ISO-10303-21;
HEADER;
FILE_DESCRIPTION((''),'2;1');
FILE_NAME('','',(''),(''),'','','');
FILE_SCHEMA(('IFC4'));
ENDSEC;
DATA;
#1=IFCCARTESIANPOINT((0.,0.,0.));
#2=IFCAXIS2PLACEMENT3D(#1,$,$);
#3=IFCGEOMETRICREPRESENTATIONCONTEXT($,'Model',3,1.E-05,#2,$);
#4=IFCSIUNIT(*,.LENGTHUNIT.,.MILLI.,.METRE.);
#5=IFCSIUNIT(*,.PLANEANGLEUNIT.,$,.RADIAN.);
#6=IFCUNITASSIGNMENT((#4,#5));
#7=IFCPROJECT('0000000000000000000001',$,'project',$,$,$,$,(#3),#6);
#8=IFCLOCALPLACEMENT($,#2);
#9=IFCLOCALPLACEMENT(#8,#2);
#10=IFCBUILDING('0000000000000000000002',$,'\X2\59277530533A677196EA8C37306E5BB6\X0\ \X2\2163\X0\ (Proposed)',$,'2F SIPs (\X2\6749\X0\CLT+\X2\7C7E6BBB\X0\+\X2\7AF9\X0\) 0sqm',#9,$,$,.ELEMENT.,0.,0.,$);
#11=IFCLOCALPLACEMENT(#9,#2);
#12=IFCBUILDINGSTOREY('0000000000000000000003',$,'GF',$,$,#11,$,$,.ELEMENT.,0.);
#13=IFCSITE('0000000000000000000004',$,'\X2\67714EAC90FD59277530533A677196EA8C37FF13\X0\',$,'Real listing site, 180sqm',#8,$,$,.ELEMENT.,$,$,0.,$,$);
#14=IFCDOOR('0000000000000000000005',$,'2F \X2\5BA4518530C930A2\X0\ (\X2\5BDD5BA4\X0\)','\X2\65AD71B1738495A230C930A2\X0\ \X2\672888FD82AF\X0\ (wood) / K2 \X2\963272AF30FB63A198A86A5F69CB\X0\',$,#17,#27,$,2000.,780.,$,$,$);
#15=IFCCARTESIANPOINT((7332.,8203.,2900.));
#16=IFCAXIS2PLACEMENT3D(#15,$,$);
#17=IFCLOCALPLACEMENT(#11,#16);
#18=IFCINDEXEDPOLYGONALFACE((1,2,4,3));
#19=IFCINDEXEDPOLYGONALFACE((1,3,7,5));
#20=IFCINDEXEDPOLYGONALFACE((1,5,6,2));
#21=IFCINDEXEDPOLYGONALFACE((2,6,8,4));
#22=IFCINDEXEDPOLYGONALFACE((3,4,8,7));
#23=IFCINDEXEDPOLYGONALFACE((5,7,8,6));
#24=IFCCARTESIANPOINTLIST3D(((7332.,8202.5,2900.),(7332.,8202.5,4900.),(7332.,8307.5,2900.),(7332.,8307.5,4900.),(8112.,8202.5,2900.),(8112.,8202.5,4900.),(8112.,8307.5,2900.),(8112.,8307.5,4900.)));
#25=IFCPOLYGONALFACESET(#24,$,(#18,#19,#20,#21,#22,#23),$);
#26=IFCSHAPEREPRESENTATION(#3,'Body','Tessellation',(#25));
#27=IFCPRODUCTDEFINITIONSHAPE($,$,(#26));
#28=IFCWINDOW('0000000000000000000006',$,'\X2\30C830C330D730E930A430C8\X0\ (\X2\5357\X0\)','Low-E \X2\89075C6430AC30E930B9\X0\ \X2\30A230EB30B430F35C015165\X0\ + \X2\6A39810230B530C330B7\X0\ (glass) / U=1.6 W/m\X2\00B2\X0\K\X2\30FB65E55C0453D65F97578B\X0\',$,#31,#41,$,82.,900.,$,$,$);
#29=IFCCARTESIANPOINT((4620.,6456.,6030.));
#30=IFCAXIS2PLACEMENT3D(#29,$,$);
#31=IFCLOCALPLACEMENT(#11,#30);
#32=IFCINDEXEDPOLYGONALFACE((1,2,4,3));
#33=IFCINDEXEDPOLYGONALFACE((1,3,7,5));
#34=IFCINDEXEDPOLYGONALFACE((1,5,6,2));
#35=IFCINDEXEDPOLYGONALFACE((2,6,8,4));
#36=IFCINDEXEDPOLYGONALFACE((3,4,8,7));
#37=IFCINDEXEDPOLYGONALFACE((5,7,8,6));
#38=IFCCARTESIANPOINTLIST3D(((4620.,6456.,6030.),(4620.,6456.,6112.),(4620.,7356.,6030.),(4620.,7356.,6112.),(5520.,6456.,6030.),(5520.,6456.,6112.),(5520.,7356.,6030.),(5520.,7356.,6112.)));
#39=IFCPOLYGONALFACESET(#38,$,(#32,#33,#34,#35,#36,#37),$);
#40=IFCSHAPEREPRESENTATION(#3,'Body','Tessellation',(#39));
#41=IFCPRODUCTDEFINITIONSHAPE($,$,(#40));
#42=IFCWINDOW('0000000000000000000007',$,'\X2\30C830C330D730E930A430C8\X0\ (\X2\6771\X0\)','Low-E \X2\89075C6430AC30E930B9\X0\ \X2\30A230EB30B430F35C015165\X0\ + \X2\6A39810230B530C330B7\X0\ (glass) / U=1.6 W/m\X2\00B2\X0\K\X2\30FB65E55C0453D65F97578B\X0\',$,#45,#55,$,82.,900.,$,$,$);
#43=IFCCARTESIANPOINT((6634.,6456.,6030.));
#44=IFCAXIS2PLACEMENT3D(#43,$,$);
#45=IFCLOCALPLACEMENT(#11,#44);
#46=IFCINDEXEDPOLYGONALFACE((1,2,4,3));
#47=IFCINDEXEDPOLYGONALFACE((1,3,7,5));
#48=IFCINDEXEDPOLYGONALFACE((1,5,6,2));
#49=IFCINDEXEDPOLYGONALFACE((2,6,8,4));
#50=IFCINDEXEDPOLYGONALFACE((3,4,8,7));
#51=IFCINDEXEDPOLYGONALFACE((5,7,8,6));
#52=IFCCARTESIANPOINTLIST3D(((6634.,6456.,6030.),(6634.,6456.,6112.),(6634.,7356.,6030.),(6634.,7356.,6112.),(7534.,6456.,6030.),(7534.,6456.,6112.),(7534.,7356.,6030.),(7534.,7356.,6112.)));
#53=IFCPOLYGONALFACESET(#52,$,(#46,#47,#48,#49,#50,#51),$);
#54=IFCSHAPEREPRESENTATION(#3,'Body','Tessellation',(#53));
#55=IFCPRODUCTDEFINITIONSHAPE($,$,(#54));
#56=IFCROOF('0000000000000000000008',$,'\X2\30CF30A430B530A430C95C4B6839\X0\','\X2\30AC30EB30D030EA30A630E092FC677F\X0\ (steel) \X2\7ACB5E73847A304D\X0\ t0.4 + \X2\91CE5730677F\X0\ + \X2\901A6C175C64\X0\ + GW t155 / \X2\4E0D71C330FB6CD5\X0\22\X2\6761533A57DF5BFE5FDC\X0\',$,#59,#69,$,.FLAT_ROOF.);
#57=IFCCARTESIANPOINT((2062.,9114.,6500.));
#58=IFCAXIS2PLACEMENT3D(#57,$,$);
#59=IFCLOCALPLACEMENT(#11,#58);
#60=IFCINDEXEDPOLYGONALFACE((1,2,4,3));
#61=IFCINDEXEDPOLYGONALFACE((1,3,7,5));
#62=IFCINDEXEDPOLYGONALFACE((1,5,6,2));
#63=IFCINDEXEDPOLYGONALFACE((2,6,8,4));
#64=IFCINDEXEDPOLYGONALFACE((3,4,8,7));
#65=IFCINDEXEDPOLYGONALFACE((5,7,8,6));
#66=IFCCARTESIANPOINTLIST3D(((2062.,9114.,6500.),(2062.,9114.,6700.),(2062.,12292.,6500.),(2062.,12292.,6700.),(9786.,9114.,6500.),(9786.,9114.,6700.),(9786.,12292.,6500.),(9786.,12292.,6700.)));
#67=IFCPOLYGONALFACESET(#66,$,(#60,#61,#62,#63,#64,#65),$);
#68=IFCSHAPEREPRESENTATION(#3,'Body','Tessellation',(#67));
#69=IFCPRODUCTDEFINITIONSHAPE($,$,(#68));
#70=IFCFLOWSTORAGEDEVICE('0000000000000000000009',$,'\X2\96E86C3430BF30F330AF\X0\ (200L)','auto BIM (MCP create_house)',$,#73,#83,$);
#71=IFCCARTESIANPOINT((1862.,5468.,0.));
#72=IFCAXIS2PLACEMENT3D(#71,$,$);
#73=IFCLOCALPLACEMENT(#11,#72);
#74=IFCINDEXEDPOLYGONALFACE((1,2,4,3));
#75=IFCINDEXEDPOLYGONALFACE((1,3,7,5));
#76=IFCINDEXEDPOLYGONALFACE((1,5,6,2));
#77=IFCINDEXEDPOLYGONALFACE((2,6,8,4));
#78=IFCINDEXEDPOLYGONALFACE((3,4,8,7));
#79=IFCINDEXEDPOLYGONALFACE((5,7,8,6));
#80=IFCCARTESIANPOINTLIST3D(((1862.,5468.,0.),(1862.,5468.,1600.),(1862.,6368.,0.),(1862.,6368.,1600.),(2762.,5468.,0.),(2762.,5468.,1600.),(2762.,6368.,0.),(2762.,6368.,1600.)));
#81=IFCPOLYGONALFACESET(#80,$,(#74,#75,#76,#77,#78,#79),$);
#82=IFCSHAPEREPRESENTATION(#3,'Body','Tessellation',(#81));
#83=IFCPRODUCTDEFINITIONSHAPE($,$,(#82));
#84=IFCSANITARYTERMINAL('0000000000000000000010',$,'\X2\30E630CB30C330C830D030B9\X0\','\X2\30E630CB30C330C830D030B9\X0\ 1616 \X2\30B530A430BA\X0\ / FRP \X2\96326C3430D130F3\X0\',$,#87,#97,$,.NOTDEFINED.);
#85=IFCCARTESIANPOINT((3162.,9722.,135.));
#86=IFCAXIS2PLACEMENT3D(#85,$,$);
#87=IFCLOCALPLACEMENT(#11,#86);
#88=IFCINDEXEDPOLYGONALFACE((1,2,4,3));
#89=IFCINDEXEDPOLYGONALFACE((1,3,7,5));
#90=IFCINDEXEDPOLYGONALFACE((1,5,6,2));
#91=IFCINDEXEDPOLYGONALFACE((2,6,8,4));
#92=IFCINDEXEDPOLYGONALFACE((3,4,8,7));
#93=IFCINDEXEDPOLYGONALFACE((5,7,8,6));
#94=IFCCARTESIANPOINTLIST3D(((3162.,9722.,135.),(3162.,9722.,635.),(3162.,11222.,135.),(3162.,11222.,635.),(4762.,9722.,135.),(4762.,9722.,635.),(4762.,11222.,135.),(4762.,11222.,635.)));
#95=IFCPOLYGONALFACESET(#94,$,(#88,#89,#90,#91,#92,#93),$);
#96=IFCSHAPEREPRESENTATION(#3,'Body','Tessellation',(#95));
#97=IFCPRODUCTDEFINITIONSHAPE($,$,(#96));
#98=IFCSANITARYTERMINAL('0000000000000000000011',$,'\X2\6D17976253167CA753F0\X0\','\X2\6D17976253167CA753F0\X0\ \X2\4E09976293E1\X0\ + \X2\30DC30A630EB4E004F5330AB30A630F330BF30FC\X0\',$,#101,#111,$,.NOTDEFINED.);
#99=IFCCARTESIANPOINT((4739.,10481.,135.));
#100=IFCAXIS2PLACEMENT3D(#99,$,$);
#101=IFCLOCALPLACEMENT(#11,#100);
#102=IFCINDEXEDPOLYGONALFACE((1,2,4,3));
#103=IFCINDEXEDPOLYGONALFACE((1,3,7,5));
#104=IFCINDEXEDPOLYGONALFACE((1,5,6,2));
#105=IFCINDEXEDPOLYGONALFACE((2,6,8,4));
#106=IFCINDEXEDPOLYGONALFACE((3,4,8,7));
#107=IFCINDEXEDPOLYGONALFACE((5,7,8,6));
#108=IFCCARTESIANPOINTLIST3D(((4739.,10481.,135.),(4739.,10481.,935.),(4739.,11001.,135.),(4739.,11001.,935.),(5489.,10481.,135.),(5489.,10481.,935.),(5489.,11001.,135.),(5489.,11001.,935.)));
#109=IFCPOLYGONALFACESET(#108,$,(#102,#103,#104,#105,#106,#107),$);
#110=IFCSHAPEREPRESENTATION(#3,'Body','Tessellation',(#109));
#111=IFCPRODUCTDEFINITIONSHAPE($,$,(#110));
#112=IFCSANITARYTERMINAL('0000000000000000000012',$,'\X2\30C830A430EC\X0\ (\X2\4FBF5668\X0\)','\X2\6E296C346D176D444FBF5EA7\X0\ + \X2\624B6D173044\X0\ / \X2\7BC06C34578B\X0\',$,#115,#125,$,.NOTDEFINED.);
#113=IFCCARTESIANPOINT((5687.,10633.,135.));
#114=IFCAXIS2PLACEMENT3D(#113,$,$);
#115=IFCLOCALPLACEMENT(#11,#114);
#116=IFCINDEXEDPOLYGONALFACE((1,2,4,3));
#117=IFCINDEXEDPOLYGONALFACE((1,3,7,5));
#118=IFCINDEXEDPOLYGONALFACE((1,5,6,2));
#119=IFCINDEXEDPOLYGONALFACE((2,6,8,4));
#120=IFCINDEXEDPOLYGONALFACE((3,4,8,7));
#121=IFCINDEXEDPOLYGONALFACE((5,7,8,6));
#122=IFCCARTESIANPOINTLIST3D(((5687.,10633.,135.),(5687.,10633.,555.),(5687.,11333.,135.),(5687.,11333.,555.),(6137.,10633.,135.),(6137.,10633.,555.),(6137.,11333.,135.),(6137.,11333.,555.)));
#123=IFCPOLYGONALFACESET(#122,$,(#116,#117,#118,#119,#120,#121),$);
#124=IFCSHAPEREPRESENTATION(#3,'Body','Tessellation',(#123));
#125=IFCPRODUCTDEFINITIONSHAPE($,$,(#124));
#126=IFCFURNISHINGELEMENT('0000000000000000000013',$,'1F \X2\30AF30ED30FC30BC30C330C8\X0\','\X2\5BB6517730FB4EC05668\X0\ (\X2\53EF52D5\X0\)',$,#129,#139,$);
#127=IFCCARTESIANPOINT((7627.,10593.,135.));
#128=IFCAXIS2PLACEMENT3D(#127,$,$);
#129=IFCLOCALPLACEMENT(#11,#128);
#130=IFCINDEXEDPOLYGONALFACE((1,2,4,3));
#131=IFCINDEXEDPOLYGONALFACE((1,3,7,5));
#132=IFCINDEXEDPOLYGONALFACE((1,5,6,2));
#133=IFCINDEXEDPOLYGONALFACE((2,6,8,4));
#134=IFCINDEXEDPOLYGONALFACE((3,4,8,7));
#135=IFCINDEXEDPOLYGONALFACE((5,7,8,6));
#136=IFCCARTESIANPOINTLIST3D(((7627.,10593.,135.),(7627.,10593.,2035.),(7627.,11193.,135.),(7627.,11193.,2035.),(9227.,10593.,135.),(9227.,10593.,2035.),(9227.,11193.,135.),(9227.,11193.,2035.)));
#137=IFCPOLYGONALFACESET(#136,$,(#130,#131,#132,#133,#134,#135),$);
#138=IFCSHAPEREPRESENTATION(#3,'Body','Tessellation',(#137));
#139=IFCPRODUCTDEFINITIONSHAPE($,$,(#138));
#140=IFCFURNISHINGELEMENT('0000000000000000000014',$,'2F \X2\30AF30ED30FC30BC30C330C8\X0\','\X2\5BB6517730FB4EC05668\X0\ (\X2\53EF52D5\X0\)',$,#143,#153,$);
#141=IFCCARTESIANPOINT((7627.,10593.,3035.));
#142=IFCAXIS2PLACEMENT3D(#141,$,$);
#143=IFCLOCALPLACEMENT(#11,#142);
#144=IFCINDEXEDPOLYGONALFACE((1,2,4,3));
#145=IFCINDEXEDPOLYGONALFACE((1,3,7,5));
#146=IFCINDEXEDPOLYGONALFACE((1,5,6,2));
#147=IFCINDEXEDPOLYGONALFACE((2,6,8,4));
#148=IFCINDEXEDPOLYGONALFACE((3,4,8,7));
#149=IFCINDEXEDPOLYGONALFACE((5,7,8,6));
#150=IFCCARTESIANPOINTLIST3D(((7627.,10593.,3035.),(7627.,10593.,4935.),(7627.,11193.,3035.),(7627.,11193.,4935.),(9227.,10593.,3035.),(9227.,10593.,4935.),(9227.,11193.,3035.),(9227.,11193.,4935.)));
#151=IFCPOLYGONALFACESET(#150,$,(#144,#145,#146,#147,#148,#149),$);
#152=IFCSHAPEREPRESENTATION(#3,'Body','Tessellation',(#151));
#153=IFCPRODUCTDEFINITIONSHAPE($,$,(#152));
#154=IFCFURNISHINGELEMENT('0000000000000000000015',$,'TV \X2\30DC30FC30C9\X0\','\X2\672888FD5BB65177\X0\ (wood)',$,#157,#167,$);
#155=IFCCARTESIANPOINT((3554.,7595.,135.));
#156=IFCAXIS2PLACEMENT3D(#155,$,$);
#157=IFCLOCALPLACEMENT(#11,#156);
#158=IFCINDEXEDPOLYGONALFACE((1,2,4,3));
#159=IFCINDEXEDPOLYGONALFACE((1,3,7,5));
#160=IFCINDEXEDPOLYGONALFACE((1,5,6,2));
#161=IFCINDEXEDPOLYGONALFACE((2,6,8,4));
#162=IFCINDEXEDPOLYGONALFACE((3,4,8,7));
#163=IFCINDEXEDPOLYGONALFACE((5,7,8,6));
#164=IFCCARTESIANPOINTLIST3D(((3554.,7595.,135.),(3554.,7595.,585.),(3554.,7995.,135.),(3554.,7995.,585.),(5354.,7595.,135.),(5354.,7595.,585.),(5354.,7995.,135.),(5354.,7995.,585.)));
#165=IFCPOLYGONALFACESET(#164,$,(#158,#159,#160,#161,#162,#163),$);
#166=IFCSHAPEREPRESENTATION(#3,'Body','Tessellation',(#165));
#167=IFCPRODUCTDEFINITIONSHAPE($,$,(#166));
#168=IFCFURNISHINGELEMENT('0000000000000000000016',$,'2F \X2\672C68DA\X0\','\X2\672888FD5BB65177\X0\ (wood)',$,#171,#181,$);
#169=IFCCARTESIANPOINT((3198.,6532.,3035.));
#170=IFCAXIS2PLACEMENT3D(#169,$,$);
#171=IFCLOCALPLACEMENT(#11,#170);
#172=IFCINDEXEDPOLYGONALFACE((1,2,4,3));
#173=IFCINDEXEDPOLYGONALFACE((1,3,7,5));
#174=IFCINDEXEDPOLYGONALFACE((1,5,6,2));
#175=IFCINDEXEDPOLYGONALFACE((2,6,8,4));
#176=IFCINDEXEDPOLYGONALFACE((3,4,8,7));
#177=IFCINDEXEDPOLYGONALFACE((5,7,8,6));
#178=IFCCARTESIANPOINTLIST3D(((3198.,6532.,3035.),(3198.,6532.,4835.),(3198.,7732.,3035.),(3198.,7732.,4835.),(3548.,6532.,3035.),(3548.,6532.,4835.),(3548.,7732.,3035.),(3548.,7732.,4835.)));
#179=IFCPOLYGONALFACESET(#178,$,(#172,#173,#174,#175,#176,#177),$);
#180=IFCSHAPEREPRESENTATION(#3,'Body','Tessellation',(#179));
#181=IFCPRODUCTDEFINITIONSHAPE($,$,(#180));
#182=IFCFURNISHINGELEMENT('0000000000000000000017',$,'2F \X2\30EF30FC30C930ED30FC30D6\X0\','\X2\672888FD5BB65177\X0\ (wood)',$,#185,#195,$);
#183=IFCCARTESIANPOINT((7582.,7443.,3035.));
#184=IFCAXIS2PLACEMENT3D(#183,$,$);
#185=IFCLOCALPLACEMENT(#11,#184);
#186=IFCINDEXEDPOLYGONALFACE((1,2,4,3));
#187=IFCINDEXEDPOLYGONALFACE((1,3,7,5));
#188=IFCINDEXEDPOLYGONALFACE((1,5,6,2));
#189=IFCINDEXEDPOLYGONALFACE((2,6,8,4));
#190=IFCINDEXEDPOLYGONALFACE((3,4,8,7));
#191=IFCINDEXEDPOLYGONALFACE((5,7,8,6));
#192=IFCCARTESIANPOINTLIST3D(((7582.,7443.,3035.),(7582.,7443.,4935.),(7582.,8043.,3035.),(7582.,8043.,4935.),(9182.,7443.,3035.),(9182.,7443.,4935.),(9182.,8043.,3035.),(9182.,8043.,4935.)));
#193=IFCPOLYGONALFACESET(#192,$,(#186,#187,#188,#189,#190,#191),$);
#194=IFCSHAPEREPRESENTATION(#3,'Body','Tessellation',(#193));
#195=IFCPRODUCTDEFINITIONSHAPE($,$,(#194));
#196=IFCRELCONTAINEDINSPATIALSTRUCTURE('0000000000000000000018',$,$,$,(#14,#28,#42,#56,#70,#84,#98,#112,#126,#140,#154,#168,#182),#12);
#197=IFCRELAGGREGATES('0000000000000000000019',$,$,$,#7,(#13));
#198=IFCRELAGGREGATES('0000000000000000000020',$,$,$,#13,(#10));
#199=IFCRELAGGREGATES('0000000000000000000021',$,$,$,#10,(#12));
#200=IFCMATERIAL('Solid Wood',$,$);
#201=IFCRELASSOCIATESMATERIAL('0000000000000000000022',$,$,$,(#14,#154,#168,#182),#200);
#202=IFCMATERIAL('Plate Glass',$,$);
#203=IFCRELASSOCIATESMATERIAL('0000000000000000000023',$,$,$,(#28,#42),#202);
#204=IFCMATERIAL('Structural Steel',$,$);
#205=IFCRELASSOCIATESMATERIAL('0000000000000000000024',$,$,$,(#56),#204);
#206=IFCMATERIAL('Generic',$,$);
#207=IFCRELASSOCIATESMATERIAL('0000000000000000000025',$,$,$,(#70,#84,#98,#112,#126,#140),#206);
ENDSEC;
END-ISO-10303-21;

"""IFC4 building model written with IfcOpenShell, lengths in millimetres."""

from ifc_helpers import new_model, si_unit, frame, frame_2d, origin, place, context, project, spatial, rectangle, extrude, material, element, save


model = new_model("IFC4")

# Units and contexts
model_context = context("Model", 3, precision=1e-05, world=origin())
ifc_project = project(units=[si_unit("LENGTHUNIT", "METRE", prefix="MILLI"), si_unit("PLANEANGLEUNIT", "RADIAN")], contexts=[model_context])

# Site, building, storey
site_placement = place(None, origin())
site = spatial("IfcSite", under=ifc_project, at=site_placement, Name="東京都大田区東雪谷３", ObjectType="Real listing site, 180sqm", CompositionType="ELEMENT", RefElevation=0.0)
building_placement = place(site_placement, origin())
building = spatial("IfcBuilding", under=site, at=building_placement, Name="大田区東雪谷の家 Ⅳ (Proposed)", ObjectType="2F SIPs (杉CLT+籾殻+竹) 0sqm", CompositionType="ELEMENT", ElevationOfRefHeight=0.0, ElevationOfTerrain=0.0)
storey_placement = place(building_placement, origin())
storey = spatial("IfcBuildingStorey", under=building, at=storey_placement, Name="GF", CompositionType="ELEMENT", Elevation=0.0)

# Shared definitions
ifc_material_1 = material(Name="Solid Wood")
ifc_material_2 = material(Name="Plate Glass")

# Door
door_1_placement = place(storey_placement, frame((7332.0, 8203.0, 2900.0)))
element("IfcDoor", 1, at=door_1_placement, inside=storey, material=ifc_material_1, Name="2F 室内ドア (寝室)", Description="断熱玄関ドア 木製芯 (wood) / K2 防犯・採風機構", OverallHeight=2000.0, OverallWidth=780.0, context=model_context, shape_type="SweptSolid", body=[
    extrude(rectangle(XDim=780.0, YDim=105.0, at=frame_2d((390.0, 52.0))), frame((7332.0, 8203.0, 2900.0)), (0.0, 0.0, 1.0), 2000.0),
])

# Windows
window_1_placement = place(storey_placement, frame((4620.0, 6456.0, 6030.0)))
element("IfcWindow", 2, at=window_1_placement, inside=storey, material=ifc_material_2, Name="トップライト (南)", Description="Low-E 複層ガラス アルゴン封入 + 樹脂サッシ (glass) / U=1.6 W/m²K・日射取得型", OverallHeight=82.0, OverallWidth=900.0, context=model_context, shape_type="SweptSolid", body=[
    extrude(rectangle(XDim=900.0, YDim=900.0, at=frame_2d((450.0, 450.0))), frame((4620.0, 6456.0, 6030.0)), (0.0, 0.0, 1.0), 82.0),
])
window_2_placement = place(storey_placement, frame((6634.0, 6456.0, 6030.0)))
element("IfcWindow", 3, at=window_2_placement, inside=storey, material=ifc_material_2, Name="トップライト (東)", Description="Low-E 複層ガラス アルゴン封入 + 樹脂サッシ (glass) / U=1.6 W/m²K・日射取得型", OverallHeight=82.0, OverallWidth=900.0, context=model_context, shape_type="SweptSolid", body=[
    extrude(rectangle(XDim=900.0, YDim=900.0, at=frame_2d((450.0, 450.0))), frame((6634.0, 6456.0, 6030.0)), (0.0, 0.0, 1.0), 82.0),
])

# Roof
ifc_material_3 = material(Name="Structural Steel")
roof_placement = place(storey_placement, frame((2062.0, 9114.0, 6500.0)))
element("IfcRoof", 4, at=roof_placement, inside=storey, material=ifc_material_3, Name="ハイサイド屋根", Description="ガルバリウム鋼板 (steel) 立平葺き t0.4 + 野地板 + 通気層 + GW t155 / 不燃・法22条区域対応", PredefinedType="FLAT_ROOF", context=model_context, shape_type="SweptSolid", body=[
    extrude(rectangle(XDim=7724.0, YDim=3178.0, at=frame_2d((3862.0, 1589.0))), frame((2062.0, 9114.0, 6500.0)), (0.0, 0.0, 1.0), 200.0),
])

# Flow storage device
ifc_material_4 = material(Name="Generic")
flow_storage_device_placement = place(storey_placement, frame((1862.0, 5468.0, 0.0)))
element("IfcFlowStorageDevice", 5, at=flow_storage_device_placement, inside=storey, material=ifc_material_4, Name="雨水タンク (200L)", Description="auto BIM (MCP create_house)", context=model_context, shape_type="SweptSolid", body=[
    extrude(rectangle(XDim=900.0, YDim=900.0, at=frame_2d((450.0, 450.0))), frame((1862.0, 5468.0, 0.0)), (0.0, 0.0, 1.0), 1600.0),
])

# Sanitary terminals
sanitary_terminal_1_placement = place(storey_placement, frame((3162.0, 9722.0, 135.0)))
element("IfcSanitaryTerminal", 6, at=sanitary_terminal_1_placement, inside=storey, material=ifc_material_4, Name="ユニットバス", Description="ユニットバス 1616 サイズ / FRP 防水パン", PredefinedType="NOTDEFINED", context=model_context, shape_type="SweptSolid", body=[
    extrude(rectangle(XDim=1600.0, YDim=1500.0, at=frame_2d((800.0, 750.0))), frame((3162.0, 9722.0, 135.0)), (0.0, 0.0, 1.0), 500.0),
])
sanitary_terminal_2_placement = place(storey_placement, frame((4739.0, 10481.0, 135.0)))
element("IfcSanitaryTerminal", 7, at=sanitary_terminal_2_placement, inside=storey, material=ifc_material_4, Name="洗面化粧台", Description="洗面化粧台 三面鏡 + ボウル一体カウンター", PredefinedType="NOTDEFINED", context=model_context, shape_type="SweptSolid", body=[
    extrude(rectangle(XDim=750.0, YDim=520.0, at=frame_2d((375.0, 260.0))), frame((4739.0, 10481.0, 135.0)), (0.0, 0.0, 1.0), 800.0),
])
sanitary_terminal_3_placement = place(storey_placement, frame((5687.0, 10633.0, 135.0)))
element("IfcSanitaryTerminal", 8, at=sanitary_terminal_3_placement, inside=storey, material=ifc_material_4, Name="トイレ (便器)", Description="温水洗浄便座 + 手洗い / 節水型", PredefinedType="NOTDEFINED", context=model_context, shape_type="SweptSolid", body=[
    extrude(rectangle(XDim=450.0, YDim=700.0, at=frame_2d((225.0, 350.0))), frame((5687.0, 10633.0, 135.0)), (0.0, 0.0, 1.0), 420.0),
])

# Furnishing elements
furnishing_1_placement = place(storey_placement, frame((7627.0, 10593.0, 135.0)))
element("IfcFurnishingElement", 9, at=furnishing_1_placement, inside=storey, material=ifc_material_4, Name="1F クローゼット", Description="家具・什器 (可動)", context=model_context, shape_type="SweptSolid", body=[
    extrude(rectangle(XDim=1600.0, YDim=600.0, at=frame_2d((800.0, 300.0))), frame((7627.0, 10593.0, 135.0)), (0.0, 0.0, 1.0), 1900.0),
])
furnishing_2_placement = place(storey_placement, frame((7627.0, 10593.0, 3035.0)))
element("IfcFurnishingElement", 10, at=furnishing_2_placement, inside=storey, material=ifc_material_4, Name="2F クローゼット", Description="家具・什器 (可動)", context=model_context, shape_type="SweptSolid", body=[
    extrude(rectangle(XDim=1600.0, YDim=600.0, at=frame_2d((800.0, 300.0))), frame((7627.0, 10593.0, 3035.0)), (0.0, 0.0, 1.0), 1900.0),
])
furnishing_3_placement = place(storey_placement, frame((3554.0, 7595.0, 135.0)))
element("IfcFurnishingElement", 11, at=furnishing_3_placement, inside=storey, material=ifc_material_1, Name="TV ボード", Description="木製家具 (wood)", context=model_context, shape_type="SweptSolid", body=[
    extrude(rectangle(XDim=1800.0, YDim=400.0, at=frame_2d((900.0, 200.0))), frame((3554.0, 7595.0, 135.0)), (0.0, 0.0, 1.0), 450.0),
])
furnishing_4_placement = place(storey_placement, frame((3198.0, 6532.0, 3035.0)))
element("IfcFurnishingElement", 12, at=furnishing_4_placement, inside=storey, material=ifc_material_1, Name="2F 本棚", Description="木製家具 (wood)", context=model_context, shape_type="SweptSolid", body=[
    extrude(rectangle(XDim=350.0, YDim=1200.0, at=frame_2d((175.0, 600.0))), frame((3198.0, 6532.0, 3035.0)), (0.0, 0.0, 1.0), 1800.0),
])
furnishing_5_placement = place(storey_placement, frame((7582.0, 7443.0, 3035.0)))
element("IfcFurnishingElement", 13, at=furnishing_5_placement, inside=storey, material=ifc_material_1, Name="2F ワードローブ", Description="木製家具 (wood)", context=model_context, shape_type="SweptSolid", body=[
    extrude(rectangle(XDim=1600.0, YDim=600.0, at=frame_2d((800.0, 300.0))), frame((7582.0, 7443.0, 3035.0)), (0.0, 0.0, 1.0), 1900.0),
])

save(model, "model.ifc")
